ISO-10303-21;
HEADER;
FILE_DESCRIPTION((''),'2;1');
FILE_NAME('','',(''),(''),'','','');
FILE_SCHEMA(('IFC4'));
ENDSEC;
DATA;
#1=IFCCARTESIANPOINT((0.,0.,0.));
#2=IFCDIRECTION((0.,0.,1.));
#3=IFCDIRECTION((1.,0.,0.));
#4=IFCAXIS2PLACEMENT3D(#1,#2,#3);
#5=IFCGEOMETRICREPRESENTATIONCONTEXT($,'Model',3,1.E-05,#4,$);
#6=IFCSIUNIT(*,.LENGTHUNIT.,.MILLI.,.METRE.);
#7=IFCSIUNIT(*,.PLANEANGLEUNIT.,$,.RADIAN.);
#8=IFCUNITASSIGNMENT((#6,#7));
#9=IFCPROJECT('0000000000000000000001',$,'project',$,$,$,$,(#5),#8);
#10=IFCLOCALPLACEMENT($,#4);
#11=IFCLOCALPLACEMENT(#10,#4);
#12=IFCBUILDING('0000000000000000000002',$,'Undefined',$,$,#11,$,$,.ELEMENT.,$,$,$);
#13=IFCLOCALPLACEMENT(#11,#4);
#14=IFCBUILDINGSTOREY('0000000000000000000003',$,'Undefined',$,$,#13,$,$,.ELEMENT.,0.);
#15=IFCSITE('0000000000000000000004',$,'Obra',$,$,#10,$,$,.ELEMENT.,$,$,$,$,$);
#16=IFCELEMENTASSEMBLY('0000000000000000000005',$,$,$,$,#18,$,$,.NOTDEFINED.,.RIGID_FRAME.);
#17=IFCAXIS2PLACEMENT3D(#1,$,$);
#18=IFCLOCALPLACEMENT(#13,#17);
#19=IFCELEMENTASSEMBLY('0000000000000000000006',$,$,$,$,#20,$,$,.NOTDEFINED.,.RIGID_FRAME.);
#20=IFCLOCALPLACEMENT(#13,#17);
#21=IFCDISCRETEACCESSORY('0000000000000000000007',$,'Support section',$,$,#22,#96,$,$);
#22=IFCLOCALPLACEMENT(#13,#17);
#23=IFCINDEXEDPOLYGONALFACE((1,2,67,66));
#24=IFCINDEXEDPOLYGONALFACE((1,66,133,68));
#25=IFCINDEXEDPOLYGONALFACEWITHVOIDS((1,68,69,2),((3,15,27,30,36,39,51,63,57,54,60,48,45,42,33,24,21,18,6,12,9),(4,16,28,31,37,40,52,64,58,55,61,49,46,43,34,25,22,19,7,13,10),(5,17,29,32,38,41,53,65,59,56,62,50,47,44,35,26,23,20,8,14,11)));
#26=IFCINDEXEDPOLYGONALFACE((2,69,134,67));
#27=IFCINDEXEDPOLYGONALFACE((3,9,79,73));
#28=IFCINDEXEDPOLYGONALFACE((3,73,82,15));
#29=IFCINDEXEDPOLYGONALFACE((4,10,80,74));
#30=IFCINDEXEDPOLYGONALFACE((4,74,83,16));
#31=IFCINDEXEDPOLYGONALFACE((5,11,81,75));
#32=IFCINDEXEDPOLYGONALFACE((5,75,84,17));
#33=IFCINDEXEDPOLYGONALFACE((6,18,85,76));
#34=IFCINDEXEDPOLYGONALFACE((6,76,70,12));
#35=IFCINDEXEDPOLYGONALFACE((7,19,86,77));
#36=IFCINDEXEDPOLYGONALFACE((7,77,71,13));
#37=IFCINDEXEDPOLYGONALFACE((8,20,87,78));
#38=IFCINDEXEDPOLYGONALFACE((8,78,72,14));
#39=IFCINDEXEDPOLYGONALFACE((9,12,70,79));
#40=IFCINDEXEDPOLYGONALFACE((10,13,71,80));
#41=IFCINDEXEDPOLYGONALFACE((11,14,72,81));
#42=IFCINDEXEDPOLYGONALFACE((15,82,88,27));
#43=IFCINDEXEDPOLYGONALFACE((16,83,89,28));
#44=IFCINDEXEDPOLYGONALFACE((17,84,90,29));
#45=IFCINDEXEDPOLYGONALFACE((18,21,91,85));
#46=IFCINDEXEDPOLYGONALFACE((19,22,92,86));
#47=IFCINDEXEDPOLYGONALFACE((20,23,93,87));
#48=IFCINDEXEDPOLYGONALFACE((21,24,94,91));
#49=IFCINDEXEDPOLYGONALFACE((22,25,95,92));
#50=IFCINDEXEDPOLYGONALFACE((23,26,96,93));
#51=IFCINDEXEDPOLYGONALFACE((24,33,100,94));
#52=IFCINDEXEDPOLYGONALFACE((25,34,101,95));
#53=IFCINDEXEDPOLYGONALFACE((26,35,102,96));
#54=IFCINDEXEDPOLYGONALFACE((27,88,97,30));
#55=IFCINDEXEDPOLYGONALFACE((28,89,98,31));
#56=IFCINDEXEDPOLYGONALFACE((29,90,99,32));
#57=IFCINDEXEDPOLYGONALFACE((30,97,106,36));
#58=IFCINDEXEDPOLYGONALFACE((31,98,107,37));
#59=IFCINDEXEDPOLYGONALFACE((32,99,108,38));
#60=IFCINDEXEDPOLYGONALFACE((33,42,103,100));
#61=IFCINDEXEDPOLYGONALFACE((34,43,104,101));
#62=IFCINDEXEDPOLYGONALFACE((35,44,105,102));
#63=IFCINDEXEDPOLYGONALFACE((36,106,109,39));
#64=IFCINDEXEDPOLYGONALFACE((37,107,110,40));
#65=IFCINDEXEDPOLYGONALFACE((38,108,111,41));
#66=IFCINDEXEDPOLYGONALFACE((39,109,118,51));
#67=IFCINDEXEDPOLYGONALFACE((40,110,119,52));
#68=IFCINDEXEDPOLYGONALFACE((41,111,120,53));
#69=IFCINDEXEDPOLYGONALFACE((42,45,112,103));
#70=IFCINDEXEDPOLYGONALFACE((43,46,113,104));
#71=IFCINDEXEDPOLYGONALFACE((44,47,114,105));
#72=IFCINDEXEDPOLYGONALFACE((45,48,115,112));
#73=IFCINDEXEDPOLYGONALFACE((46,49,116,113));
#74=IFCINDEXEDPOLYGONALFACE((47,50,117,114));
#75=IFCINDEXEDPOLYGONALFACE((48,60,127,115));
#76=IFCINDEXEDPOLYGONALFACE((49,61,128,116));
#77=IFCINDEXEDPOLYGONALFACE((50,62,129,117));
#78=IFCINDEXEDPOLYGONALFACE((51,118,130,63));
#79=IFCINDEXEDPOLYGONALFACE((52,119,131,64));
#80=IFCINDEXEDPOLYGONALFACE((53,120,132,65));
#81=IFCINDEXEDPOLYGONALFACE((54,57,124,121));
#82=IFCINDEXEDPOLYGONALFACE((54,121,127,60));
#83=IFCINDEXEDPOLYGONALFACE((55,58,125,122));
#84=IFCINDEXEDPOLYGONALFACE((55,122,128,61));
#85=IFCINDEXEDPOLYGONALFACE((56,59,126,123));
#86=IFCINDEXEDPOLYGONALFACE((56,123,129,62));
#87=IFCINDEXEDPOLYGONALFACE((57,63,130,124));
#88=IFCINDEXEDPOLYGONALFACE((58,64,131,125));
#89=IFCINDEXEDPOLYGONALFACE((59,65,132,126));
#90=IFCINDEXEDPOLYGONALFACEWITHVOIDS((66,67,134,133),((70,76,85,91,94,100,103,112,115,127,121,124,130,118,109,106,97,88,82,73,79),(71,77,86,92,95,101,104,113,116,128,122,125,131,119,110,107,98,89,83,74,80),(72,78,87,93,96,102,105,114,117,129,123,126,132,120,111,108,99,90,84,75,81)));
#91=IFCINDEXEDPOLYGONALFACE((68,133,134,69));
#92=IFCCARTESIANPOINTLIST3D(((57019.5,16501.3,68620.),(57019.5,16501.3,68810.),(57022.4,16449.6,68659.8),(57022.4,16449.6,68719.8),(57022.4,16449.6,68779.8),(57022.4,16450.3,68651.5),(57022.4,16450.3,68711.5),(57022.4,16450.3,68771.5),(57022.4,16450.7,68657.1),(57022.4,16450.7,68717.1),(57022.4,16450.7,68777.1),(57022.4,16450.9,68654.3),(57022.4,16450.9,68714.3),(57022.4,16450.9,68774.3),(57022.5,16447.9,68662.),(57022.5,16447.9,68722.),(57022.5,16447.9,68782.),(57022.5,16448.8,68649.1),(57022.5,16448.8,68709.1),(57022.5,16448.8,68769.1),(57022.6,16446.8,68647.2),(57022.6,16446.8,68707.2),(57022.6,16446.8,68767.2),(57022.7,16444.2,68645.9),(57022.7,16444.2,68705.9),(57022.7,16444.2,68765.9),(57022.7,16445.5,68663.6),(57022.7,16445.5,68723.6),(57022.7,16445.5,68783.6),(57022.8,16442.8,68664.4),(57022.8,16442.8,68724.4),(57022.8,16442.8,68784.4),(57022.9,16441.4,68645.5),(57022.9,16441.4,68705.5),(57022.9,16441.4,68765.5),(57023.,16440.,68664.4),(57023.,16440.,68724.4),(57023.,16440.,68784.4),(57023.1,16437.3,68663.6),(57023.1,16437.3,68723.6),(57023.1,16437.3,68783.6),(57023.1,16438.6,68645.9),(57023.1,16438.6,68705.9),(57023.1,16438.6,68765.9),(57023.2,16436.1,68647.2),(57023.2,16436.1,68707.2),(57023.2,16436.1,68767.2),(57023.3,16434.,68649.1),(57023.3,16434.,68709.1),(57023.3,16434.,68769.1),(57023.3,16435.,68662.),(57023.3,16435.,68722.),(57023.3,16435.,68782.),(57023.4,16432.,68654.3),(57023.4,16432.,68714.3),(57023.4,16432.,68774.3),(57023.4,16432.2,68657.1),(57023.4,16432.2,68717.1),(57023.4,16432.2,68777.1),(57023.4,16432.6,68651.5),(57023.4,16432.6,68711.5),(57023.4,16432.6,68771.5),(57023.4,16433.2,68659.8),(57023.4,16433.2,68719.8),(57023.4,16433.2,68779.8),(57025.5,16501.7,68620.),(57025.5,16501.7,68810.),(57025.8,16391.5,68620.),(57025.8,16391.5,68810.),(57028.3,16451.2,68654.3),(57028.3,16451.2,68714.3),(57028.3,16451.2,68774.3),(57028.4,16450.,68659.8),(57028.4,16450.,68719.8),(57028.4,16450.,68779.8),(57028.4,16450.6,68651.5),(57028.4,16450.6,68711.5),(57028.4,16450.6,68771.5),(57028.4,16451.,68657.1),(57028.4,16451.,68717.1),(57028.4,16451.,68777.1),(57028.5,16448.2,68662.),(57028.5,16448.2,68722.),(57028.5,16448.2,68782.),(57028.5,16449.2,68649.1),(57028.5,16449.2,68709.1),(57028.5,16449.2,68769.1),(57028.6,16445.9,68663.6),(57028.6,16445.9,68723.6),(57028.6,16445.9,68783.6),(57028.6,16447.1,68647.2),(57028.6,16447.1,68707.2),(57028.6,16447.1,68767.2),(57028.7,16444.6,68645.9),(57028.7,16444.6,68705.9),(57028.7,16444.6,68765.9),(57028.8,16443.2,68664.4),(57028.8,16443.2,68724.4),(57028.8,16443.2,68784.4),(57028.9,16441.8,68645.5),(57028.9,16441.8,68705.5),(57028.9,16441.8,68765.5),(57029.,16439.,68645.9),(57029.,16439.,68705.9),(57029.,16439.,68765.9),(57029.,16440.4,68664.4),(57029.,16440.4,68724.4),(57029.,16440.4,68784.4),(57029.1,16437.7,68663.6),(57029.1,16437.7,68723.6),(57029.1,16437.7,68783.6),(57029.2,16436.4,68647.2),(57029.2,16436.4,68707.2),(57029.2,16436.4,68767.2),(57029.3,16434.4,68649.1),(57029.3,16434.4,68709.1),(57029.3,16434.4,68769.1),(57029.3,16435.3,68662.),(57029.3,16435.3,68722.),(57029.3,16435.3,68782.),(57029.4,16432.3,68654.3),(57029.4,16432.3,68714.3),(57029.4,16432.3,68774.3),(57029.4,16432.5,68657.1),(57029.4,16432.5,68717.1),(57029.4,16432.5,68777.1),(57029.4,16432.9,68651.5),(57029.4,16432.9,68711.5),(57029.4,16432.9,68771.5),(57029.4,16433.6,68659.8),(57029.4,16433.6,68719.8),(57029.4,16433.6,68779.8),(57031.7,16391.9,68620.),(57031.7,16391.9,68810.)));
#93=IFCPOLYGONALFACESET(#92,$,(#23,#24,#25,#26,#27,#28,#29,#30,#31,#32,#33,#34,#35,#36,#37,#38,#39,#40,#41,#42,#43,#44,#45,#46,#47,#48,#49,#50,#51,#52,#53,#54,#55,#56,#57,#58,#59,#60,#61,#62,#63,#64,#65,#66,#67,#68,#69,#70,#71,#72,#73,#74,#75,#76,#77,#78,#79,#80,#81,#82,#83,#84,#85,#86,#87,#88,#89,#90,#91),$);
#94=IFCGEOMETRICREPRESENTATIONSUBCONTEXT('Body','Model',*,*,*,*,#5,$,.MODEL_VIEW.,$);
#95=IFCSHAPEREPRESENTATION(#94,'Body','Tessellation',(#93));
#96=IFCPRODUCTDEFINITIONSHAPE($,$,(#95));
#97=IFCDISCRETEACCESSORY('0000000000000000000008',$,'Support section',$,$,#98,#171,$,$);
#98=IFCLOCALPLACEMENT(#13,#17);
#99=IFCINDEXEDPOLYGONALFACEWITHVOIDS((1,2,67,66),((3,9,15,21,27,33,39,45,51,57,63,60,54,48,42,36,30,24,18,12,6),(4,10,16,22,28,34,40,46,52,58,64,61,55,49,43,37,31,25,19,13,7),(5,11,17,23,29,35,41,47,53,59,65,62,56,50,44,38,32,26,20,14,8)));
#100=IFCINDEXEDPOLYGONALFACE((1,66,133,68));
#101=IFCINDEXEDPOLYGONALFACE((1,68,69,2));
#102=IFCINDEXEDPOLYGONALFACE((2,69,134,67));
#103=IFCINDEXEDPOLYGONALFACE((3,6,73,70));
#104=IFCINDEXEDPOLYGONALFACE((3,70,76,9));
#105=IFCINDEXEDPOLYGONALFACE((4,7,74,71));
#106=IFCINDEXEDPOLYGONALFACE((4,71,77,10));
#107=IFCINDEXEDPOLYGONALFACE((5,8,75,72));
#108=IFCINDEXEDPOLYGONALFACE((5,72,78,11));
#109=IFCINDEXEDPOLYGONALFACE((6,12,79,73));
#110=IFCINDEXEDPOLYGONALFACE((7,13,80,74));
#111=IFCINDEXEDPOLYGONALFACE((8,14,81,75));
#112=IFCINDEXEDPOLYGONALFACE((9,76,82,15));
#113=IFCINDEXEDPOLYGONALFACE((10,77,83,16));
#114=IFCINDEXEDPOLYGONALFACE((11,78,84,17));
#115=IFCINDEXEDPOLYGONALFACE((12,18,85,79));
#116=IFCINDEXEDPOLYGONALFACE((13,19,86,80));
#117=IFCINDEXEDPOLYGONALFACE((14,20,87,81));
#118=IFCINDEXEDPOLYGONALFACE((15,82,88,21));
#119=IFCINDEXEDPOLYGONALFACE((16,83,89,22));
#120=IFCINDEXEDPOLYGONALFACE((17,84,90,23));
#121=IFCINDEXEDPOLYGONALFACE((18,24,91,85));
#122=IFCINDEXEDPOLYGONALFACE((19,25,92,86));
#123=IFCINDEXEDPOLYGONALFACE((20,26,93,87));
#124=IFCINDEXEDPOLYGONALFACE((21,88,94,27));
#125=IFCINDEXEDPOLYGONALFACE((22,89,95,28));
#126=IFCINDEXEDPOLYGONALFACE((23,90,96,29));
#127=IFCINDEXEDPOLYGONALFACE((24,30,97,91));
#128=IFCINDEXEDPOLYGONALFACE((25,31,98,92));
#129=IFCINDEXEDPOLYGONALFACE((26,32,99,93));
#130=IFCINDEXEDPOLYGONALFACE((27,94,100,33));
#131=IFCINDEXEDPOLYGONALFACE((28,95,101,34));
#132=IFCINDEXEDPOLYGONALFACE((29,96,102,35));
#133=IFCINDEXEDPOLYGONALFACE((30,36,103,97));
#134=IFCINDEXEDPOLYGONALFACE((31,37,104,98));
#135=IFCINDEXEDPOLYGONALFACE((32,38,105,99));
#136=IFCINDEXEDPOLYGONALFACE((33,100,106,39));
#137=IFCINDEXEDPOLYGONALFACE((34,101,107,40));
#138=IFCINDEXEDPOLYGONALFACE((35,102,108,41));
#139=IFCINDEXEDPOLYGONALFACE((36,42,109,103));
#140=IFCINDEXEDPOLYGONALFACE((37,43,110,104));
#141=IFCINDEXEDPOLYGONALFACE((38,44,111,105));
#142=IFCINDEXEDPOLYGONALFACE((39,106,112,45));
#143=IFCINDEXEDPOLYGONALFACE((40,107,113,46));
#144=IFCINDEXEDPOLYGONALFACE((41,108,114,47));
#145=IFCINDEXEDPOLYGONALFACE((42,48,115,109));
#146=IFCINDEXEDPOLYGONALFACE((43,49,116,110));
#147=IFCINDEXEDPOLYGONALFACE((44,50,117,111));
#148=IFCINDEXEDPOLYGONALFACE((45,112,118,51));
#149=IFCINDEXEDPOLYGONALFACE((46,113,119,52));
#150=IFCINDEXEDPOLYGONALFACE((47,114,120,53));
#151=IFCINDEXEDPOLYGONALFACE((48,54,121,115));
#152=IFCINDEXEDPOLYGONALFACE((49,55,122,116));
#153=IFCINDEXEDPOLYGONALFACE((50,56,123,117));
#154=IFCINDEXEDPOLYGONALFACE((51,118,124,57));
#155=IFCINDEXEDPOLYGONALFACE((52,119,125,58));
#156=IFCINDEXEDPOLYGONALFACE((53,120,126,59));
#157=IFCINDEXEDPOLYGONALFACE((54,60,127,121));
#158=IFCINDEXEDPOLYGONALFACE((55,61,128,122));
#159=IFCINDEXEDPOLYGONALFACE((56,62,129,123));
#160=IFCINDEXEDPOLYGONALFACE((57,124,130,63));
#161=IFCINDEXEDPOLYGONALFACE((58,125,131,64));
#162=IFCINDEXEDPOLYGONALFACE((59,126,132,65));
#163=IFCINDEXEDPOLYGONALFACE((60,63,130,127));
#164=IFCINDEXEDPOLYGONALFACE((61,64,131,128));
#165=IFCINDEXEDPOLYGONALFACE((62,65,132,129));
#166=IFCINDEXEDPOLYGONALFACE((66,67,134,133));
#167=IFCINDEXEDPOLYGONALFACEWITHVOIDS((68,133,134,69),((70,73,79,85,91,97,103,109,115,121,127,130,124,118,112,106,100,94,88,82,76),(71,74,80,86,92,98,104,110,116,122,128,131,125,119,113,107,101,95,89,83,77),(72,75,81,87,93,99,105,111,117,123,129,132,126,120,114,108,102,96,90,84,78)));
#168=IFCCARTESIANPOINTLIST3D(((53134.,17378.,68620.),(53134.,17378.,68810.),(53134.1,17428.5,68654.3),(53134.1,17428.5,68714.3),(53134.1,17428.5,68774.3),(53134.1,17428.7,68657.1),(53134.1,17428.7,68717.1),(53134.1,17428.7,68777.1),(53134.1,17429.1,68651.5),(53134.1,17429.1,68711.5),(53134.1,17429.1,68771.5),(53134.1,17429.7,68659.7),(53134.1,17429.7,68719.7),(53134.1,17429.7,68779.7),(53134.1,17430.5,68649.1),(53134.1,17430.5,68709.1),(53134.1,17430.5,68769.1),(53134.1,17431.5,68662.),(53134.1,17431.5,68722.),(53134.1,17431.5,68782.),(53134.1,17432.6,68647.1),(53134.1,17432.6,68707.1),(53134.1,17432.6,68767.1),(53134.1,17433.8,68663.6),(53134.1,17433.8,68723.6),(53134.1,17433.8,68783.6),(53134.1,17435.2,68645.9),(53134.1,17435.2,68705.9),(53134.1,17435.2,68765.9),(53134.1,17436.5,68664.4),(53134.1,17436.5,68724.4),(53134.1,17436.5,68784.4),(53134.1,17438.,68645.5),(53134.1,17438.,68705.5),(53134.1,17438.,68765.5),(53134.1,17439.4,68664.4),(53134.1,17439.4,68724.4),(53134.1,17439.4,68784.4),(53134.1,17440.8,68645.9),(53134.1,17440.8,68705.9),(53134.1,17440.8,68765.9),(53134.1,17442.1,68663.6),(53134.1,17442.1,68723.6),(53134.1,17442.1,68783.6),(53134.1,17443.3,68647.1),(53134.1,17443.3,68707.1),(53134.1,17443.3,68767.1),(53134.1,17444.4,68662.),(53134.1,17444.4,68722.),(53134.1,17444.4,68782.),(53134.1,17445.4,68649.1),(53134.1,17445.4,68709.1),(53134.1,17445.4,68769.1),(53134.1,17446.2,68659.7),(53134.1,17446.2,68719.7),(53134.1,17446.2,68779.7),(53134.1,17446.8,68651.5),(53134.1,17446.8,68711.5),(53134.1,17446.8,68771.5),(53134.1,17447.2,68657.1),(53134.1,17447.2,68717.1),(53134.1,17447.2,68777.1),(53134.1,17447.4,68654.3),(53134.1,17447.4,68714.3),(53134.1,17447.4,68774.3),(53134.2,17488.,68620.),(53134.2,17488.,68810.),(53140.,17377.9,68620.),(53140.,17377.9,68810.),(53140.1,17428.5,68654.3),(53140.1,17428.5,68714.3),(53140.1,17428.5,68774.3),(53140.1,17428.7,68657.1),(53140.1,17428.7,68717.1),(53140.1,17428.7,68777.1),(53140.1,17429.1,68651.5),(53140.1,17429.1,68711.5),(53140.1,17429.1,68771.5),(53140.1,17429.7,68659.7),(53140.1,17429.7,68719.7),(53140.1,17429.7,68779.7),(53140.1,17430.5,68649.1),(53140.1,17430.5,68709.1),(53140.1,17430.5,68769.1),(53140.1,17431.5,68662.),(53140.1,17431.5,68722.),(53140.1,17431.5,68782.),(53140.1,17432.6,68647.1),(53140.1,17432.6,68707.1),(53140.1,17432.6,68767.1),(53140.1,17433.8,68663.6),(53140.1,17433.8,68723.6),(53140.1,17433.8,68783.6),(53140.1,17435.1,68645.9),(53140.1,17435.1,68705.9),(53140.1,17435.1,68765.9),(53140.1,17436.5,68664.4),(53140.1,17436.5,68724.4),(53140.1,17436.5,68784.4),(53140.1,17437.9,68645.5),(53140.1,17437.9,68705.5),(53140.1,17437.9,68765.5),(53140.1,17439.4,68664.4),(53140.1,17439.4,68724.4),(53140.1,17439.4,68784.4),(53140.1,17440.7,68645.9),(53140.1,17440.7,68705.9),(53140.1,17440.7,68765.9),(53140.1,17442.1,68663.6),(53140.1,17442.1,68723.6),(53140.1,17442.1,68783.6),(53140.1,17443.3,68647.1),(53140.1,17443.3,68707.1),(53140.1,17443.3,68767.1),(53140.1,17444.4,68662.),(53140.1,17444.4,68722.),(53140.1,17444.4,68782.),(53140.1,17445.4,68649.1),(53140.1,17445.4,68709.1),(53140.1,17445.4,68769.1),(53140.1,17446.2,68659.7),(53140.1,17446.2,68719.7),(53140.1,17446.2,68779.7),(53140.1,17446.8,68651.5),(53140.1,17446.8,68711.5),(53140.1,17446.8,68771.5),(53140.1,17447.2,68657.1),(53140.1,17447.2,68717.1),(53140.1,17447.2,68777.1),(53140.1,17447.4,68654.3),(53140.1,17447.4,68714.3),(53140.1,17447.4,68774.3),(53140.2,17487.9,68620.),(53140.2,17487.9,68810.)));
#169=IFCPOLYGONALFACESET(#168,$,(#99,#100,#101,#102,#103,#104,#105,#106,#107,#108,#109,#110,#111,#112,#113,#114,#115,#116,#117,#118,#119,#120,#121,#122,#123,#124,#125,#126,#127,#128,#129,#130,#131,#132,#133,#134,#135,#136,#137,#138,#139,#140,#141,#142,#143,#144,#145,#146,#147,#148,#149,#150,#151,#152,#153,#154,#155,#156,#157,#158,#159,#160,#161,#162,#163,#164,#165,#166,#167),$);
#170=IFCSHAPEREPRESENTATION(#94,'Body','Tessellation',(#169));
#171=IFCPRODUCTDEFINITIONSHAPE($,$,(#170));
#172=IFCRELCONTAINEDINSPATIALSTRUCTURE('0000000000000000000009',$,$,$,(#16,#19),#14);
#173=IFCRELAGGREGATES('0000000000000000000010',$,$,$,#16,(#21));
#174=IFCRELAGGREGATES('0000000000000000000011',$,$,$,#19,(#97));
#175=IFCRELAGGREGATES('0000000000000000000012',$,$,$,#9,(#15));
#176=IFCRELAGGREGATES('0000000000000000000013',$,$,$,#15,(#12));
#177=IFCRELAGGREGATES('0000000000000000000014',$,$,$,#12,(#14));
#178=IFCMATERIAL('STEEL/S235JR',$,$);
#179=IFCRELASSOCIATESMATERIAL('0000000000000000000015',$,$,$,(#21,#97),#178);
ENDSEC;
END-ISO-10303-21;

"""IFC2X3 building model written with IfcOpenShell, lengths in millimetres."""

from ifc_helpers import new_model, si_unit, frame, origin_with_axes, origin_2d_with_axis, place, context, subcontext, project, spatial, rectangle, circle, extrude, source, transform, mapped, material, element, aggregate, save


model = new_model("IFC2X3")

# Units and contexts
model_context = context("Model", 3, precision=1e-05, world=origin_with_axes())
body_context = subcontext(model_context, "Body", "Model", "MODEL_VIEW")
ifc_project = project(units=[si_unit("LENGTHUNIT", "METRE", prefix="MILLI"), si_unit("PLANEANGLEUNIT", "RADIAN")], contexts=[model_context])

# Site, building, storey
site_placement = place(None, origin_with_axes())
site = spatial("IfcSite", under=ifc_project, at=site_placement, Name="Obra", CompositionType="ELEMENT")
building_placement = place(site_placement, origin_with_axes())
building = spatial("IfcBuilding", under=site, at=building_placement, Name="Undefined", CompositionType="ELEMENT")
storey_placement = place(building_placement, origin_with_axes())
storey = spatial("IfcBuildingStorey", under=building, at=storey_placement, Name="Undefined", CompositionType="ELEMENT", Elevation=0.0)

# Element assemblies
ifc_material_1 = material(Name="STEEL/S235JR")
assembly_1_placement = place(storey_placement, origin_with_axes())
assembly_1 = element("IfcElementAssembly", 1, at=assembly_1_placement, inside=storey, AssemblyPlace="NOTDEFINED", PredefinedType="RIGID_FRAME")
assembly_2_placement = place(storey_placement, origin_with_axes())
assembly_2 = element("IfcElementAssembly", 2, at=assembly_2_placement, inside=storey, AssemblyPlace="NOTDEFINED", PredefinedType="RIGID_FRAME")

# Discrete accessories, openings
shared_shape_1 = source(origin_with_axes(), body_context, "Body", "SweptSolid", [
    extrude(circle(Radius=9.5, at=origin_2d_with_axis()), frame((0.0, -9.2, 0.0), z_axis=(0.0, 1.0, 0.0), x_axis=(1.0, 0.0, 0.0)), (0.0, 0.0, 1.0), 6.2),
])
discrete_accessory_1_placement = place(assembly_1_placement, frame((57025.6, 16446.6, 68620.0), z_axis=(0.0, 0.0, 1.0), x_axis=(-0.057107, 0.998368, 0.0)))
discrete_accessory_1 = element("IfcDiscreteAccessory", 3, at=discrete_accessory_1_placement, material=ifc_material_1, Name="Support section", context=body_context, shape_type="SweptSolid", body=[
    extrude(rectangle(XDim=6.0, YDim=110.0, at=origin_2d_with_axis()), frame((0.0, 0.0, 190.0), z_axis=(0.0, 0.0, -1.0), x_axis=(0.0, 1.0, 0.0)), (0.0, 0.0, 1.0), 190.0),
])
opening_1_placement = place(assembly_1_placement, frame((57029.1, 16491.9, 68835.0), z_axis=(0.057107, -0.998368, 0.0), x_axis=(0.0, 0.0, -1.0)))
element("IfcOpeningElement", 4, at=opening_1_placement, cuts=discrete_accessory_1, ObjectType="Opening", context=body_context, shape_type="MappedRepresentation", body=[
    mapped(shared_shape_1, transform((60.0, 0.0, 50.0))),
    mapped(shared_shape_1, transform((120.0, 0.0, 50.0))),
    mapped(shared_shape_1, transform((180.0, 0.0, 50.0))),
])
aggregate(assembly_1, [discrete_accessory_1])
discrete_accessory_2_placement = place(assembly_2_placement, frame((53137.1, 17433.0, 68620.0), z_axis=(0.0, 0.0, 1.0), x_axis=(-0.001649, -0.999999, 0.0)))
discrete_accessory_2 = element("IfcDiscreteAccessory", 5, at=discrete_accessory_2_placement, material=ifc_material_1, Name="Support section", context=body_context, shape_type="SweptSolid", body=[
    extrude(rectangle(XDim=6.0, YDim=110.0, at=origin_2d_with_axis()), frame((0.0, 0.0, 190.0), z_axis=(0.0, 0.0, -1.0), x_axis=(0.0, 1.0, 0.0)), (0.0, 0.0, 1.0), 190.0),
])
opening_2_placement = place(assembly_2_placement, frame((53130.9, 17388.0, 68835.0), z_axis=(0.001649, 0.999999, 0.0), x_axis=(0.0, 0.0, -1.0)))
element("IfcOpeningElement", 6, at=opening_2_placement, cuts=discrete_accessory_2, ObjectType="Opening", context=body_context, shape_type="MappedRepresentation", body=[
    mapped(shared_shape_1, transform((60.0, 0.0, 50.0))),
    mapped(shared_shape_1, transform((120.0, 0.0, 50.0))),
    mapped(shared_shape_1, transform((180.0, 0.0, 50.0))),
])
aggregate(assembly_2, [discrete_accessory_2])

save(model, "model.ifc")
